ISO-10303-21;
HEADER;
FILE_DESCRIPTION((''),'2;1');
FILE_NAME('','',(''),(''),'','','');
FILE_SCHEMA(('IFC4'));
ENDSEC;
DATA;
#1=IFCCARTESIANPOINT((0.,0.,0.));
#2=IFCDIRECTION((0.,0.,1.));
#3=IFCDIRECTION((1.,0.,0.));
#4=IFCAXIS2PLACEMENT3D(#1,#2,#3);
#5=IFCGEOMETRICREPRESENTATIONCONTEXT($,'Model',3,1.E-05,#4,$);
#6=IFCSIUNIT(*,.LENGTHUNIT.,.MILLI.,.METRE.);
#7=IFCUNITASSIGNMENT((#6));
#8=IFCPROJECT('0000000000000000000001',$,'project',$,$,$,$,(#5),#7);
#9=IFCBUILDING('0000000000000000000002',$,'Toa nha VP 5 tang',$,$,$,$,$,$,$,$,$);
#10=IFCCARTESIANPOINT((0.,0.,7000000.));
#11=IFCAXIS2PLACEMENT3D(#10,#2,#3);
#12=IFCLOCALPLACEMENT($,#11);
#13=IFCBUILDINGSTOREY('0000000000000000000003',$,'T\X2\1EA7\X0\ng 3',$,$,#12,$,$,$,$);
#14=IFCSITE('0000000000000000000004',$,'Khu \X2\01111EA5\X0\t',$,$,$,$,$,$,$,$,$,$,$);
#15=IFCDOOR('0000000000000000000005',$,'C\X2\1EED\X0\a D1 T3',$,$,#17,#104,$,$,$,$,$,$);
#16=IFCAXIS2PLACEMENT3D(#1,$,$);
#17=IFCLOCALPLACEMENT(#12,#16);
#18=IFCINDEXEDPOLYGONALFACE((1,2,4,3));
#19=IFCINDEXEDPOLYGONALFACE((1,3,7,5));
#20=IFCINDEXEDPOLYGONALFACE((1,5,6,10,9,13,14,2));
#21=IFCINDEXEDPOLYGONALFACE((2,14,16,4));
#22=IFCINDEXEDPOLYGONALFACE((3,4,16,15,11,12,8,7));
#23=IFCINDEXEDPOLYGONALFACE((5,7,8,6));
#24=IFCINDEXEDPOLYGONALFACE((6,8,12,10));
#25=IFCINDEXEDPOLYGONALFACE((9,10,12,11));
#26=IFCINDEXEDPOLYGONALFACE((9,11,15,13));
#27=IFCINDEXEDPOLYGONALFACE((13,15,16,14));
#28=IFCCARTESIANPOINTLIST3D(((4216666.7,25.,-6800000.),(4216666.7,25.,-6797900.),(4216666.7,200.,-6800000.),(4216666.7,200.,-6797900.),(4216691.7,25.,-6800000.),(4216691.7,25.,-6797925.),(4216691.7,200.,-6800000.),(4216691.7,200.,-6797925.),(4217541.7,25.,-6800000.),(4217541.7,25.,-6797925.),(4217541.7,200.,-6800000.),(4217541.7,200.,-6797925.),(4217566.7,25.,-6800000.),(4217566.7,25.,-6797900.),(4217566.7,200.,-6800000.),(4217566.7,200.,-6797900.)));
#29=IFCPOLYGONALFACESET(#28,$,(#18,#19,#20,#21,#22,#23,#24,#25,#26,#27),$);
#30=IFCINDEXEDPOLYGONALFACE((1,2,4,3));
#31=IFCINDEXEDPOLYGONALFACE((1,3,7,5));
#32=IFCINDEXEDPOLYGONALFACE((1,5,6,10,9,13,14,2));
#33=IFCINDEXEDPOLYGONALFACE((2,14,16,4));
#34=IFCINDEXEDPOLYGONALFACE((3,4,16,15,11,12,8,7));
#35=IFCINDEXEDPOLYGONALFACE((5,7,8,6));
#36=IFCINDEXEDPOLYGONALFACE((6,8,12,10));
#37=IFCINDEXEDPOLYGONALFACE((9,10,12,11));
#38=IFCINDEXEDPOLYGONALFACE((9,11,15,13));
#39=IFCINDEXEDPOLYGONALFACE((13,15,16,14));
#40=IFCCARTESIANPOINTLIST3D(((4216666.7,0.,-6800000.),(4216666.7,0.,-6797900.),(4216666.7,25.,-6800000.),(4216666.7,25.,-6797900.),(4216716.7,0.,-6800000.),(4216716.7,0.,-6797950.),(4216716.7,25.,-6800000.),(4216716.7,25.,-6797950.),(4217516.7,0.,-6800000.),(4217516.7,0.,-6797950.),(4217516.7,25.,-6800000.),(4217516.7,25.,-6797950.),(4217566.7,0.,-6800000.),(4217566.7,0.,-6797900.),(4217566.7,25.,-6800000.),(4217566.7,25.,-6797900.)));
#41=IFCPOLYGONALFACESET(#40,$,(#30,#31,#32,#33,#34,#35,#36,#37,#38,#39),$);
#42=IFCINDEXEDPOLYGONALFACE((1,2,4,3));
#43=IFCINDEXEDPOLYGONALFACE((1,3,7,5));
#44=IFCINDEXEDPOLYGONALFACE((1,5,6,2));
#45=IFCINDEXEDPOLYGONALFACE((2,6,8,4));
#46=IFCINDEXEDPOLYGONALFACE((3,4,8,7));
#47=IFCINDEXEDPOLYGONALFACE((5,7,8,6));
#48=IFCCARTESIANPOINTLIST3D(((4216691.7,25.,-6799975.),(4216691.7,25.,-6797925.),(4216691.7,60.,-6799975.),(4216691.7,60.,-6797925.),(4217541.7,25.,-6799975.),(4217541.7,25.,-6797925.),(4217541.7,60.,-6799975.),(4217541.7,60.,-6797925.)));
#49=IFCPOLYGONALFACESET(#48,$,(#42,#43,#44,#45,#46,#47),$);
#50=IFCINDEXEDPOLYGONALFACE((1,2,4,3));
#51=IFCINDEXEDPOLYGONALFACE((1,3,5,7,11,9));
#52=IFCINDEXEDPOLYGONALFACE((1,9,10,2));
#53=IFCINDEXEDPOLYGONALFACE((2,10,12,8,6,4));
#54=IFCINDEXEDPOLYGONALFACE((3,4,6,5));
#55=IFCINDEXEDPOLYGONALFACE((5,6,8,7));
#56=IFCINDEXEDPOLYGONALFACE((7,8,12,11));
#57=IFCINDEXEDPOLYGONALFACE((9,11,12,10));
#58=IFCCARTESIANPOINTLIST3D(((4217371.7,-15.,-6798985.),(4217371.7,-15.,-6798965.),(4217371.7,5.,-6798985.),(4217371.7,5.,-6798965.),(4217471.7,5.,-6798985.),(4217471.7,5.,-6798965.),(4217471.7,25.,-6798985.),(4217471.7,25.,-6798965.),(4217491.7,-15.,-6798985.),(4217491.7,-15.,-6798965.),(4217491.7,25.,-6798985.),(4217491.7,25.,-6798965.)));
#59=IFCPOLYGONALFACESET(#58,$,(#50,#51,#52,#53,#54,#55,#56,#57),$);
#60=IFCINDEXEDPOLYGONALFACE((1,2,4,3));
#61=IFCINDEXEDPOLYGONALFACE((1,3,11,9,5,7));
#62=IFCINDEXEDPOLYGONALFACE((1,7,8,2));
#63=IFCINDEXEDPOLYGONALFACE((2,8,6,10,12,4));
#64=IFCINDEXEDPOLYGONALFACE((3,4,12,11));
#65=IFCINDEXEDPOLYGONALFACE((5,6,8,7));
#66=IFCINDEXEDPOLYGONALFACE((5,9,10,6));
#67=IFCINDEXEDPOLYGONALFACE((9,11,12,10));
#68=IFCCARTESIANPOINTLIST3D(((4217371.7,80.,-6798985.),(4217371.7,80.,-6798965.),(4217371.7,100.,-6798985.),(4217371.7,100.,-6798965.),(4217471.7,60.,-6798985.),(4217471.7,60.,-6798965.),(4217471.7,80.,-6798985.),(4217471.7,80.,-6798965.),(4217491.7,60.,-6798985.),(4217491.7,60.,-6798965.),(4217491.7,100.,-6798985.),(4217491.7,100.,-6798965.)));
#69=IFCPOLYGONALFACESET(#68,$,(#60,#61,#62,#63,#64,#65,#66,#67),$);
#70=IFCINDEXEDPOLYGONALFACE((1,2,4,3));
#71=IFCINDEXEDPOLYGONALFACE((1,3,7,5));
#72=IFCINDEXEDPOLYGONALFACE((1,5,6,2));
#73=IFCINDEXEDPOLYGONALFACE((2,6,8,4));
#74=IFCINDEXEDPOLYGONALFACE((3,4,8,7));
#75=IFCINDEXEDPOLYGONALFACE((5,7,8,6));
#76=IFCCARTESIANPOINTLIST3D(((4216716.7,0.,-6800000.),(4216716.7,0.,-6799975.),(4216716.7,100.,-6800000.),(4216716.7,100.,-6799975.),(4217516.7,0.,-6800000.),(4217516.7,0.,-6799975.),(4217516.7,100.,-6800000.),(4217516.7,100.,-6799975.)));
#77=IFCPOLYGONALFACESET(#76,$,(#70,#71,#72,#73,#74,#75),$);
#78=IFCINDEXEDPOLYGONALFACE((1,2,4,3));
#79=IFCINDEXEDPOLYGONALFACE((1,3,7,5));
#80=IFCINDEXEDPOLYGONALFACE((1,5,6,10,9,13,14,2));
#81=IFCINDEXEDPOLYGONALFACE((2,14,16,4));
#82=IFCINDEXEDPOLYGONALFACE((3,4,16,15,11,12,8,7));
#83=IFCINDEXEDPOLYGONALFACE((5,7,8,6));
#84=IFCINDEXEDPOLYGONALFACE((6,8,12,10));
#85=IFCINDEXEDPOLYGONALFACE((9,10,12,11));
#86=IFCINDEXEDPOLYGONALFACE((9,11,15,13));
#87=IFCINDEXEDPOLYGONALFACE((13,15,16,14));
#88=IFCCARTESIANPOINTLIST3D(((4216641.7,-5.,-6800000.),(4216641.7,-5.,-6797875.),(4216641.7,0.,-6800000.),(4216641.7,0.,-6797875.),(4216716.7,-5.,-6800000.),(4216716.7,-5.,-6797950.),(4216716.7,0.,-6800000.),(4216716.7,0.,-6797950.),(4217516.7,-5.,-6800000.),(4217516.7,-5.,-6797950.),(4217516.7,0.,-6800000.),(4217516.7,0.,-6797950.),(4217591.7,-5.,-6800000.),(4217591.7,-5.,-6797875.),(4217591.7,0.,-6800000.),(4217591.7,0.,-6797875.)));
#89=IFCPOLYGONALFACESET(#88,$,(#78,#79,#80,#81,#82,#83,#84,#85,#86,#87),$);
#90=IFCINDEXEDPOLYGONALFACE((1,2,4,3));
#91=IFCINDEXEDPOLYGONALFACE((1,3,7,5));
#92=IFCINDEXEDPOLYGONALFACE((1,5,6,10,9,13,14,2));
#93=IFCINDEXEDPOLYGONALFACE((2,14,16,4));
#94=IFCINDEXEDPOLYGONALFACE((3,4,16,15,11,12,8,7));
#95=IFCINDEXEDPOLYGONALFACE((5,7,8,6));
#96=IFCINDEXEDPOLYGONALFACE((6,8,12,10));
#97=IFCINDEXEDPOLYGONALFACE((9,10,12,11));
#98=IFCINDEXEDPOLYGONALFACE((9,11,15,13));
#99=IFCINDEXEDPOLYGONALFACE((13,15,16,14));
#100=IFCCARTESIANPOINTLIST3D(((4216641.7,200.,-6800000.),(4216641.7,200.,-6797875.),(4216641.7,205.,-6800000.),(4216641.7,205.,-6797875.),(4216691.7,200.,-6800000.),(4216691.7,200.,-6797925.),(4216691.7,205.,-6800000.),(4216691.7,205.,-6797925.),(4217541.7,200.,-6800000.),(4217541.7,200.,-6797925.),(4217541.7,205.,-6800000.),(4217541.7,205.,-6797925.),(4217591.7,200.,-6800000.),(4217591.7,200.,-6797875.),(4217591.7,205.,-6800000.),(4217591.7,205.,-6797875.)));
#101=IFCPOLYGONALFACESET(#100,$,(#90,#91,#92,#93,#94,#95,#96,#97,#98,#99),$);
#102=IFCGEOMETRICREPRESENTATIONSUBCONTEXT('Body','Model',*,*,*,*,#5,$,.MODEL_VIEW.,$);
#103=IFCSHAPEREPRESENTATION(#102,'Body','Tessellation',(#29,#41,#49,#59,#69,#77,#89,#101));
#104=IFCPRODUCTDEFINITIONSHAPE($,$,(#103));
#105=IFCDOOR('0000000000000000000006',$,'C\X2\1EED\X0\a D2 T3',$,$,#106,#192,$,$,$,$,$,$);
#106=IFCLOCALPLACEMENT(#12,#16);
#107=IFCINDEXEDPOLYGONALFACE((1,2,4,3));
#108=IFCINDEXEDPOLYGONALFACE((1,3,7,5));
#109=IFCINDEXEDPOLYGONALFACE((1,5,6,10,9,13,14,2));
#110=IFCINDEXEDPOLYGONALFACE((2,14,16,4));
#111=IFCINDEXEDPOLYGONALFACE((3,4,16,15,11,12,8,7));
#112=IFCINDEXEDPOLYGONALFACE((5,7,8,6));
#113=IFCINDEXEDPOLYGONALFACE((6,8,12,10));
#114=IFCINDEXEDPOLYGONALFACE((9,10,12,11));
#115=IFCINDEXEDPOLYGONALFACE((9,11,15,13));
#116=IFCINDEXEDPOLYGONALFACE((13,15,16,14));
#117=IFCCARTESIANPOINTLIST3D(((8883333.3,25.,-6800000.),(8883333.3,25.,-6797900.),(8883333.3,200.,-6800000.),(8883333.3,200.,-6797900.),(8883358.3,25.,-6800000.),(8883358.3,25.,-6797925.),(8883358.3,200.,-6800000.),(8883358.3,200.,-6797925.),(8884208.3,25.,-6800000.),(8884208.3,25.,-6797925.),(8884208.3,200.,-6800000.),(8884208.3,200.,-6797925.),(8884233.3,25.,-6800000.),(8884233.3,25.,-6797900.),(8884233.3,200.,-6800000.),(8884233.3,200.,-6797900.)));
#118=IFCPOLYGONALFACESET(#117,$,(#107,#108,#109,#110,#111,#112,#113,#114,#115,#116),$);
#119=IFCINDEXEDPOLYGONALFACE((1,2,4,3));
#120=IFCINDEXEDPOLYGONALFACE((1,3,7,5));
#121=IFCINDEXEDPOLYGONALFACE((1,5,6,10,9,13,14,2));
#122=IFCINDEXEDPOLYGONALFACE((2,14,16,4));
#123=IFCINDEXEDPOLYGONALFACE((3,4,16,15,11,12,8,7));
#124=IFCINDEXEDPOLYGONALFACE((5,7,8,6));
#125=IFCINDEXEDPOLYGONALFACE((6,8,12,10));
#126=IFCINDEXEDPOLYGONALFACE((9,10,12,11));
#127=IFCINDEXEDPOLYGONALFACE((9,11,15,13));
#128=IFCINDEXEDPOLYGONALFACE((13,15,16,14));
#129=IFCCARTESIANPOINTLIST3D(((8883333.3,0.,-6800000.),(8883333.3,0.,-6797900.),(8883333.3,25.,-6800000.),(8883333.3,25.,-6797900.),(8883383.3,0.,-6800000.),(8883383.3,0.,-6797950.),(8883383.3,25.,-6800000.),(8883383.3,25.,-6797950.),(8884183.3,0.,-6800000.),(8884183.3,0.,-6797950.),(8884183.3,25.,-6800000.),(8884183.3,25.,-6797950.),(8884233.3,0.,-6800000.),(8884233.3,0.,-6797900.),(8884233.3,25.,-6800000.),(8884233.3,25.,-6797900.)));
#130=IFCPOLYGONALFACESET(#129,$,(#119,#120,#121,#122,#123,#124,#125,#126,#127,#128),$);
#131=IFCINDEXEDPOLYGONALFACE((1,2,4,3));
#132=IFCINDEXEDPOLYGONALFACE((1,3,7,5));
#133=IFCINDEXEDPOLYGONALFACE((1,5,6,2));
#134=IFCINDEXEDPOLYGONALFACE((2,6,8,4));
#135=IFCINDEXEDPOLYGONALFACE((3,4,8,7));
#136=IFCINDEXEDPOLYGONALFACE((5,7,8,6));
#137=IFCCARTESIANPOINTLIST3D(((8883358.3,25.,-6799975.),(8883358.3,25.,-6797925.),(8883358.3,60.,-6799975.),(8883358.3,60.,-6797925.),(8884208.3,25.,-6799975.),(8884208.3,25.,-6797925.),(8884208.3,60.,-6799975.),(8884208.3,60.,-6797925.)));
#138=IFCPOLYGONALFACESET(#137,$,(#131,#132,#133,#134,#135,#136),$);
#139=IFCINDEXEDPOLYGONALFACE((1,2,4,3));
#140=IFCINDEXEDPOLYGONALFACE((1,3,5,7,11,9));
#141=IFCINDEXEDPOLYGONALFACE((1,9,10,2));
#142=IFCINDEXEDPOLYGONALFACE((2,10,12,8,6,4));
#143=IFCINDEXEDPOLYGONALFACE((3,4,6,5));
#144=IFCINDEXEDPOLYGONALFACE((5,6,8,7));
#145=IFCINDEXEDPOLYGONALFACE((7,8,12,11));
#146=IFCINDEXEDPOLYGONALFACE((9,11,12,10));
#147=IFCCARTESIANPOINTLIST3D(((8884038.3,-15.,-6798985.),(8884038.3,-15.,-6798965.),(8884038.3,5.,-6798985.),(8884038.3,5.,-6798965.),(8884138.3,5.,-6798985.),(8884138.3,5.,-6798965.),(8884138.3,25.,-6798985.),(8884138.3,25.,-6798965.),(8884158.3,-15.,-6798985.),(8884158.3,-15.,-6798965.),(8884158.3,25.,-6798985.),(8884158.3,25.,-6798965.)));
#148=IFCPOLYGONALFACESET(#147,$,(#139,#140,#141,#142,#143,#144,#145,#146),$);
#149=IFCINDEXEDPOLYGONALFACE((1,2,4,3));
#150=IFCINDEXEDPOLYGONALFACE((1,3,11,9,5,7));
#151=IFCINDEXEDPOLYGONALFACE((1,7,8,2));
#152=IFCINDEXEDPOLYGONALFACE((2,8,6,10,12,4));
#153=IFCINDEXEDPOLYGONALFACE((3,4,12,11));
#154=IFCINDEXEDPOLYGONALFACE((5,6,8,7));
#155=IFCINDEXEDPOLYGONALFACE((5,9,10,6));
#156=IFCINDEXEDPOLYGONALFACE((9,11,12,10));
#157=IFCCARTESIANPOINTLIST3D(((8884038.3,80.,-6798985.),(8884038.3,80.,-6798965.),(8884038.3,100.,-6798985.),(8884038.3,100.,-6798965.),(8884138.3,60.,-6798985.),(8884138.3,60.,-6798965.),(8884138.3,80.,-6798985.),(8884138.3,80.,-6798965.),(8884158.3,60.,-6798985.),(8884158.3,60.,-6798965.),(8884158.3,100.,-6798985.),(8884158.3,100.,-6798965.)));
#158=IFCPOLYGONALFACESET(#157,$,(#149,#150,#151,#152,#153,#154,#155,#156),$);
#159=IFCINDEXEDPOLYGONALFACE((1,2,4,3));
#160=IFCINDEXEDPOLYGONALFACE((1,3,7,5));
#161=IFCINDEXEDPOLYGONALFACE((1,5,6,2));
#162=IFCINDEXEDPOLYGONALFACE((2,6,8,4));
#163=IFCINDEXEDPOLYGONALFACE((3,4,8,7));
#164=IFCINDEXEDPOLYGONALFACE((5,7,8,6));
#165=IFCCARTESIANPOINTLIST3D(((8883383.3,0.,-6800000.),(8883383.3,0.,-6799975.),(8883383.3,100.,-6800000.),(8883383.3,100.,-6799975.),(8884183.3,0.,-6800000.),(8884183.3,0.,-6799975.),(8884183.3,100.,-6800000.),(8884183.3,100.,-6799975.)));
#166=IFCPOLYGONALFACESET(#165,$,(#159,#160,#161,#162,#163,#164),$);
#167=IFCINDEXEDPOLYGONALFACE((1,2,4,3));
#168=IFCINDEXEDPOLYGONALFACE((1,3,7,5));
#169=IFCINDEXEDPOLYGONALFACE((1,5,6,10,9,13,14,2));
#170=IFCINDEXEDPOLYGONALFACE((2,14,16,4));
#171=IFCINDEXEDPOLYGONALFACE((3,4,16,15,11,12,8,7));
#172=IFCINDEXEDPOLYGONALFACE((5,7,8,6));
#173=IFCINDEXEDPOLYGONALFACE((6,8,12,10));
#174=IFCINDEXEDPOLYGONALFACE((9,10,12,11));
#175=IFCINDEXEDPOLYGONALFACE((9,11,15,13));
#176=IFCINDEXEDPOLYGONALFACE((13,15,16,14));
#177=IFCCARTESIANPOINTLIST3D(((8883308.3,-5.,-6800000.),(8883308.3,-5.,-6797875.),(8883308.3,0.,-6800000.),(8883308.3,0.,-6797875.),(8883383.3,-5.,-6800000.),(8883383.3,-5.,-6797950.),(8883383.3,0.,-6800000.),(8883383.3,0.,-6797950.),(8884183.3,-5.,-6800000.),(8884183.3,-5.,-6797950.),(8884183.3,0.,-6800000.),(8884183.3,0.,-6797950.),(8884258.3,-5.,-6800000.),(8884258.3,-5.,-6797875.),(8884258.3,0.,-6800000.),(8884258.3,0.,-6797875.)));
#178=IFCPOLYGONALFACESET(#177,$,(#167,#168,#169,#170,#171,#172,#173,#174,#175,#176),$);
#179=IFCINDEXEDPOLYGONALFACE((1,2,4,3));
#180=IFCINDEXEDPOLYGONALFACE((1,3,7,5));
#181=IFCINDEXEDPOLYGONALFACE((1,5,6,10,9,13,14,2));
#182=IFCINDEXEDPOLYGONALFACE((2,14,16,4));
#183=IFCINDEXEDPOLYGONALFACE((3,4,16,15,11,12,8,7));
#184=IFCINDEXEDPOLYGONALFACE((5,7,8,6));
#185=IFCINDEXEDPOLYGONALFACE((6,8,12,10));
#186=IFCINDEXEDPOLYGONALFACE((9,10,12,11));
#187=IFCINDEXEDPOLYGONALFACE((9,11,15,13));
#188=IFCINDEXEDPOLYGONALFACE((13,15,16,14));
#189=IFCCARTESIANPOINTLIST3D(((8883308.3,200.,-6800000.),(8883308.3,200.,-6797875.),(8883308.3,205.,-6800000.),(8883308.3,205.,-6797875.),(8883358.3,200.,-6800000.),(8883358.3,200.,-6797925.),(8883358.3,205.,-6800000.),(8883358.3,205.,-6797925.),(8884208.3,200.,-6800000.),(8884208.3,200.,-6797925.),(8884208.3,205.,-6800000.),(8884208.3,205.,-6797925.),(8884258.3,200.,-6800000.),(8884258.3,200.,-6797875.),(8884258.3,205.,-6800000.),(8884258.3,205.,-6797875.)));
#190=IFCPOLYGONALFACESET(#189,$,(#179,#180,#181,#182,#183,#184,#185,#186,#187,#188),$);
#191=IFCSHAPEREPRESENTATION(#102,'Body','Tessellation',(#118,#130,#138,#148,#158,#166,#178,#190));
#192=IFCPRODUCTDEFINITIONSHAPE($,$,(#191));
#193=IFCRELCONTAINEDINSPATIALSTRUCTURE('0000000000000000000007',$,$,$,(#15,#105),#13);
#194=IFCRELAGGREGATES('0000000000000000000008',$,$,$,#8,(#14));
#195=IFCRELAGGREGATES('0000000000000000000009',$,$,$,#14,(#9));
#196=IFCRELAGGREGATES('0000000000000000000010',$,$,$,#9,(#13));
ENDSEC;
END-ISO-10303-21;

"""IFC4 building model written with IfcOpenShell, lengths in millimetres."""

from ifc_helpers import new_model, si_unit, frame, origin_with_axes, place, context, subcontext, project, spatial, line, indexed_curve, outline, extrude, element, save


model = new_model("IFC4")

# Units and contexts
model_context = context("Model", 3, precision=1e-05, world=origin_with_axes())
body_context = subcontext(model_context, "Body", "Model", "MODEL_VIEW")
ifc_project = project(units=[si_unit("LENGTHUNIT", "METRE", prefix="MILLI")], contexts=[model_context])

# Site, building, storey
site = spatial("IfcSite", under=ifc_project, Name="Khu đất")
building = spatial("IfcBuilding", under=site, Name="Toa nha VP 5 tang")
storey_placement = place(None, frame((0.0, 0.0, 7000000.0), z_axis=(0.0, 0.0, 1.0), x_axis=(1.0, 0.0, 0.0)))
storey = spatial("IfcBuildingStorey", under=building, at=storey_placement, Name="Tầng 3")

# Doors
door_1_placement = place(storey_placement, frame((4216666.7, 0.0, -6800000.0), z_axis=(0.0, 0.0, 1.0), x_axis=(1.0, 0.0, 0.0)))
element("IfcDoor", 1, at=door_1_placement, inside=storey, Name="Cửa D1 T3", context=body_context, shape_type="SolidModel", body=[
    extrude(outline(indexed_curve([(0.0, 0.0), (0.0, 2100.0), (900.0, 2100.0), (900.0, 0.0), (875.0, 0.0), (875.0, 2075.0), (25.0, 2075.0), (25.0, 0.0)], segments=[line(1, 2, 3, 4, 5, 6, 7, 8, 1)])), frame((0.0, 25.0, 0.0), z_axis=(0.0, -1.0, 0.0), x_axis=(1.0, 0.0, 0.0)), (0.0, 0.0, -1.0), 175.0),
    extrude(outline(indexed_curve([(0.0, 0.0), (0.0, 2100.0), (900.0, 2100.0), (900.0, 0.0), (850.0, 0.0), (850.0, 2050.0), (50.0, 2050.0), (50.0, 0.0)], segments=[line(1, 2, 3, 4, 5, 6, 7, 8, 1)])), frame((0.0, 0.0, 0.0), z_axis=(0.0, -1.0, 0.0), x_axis=(1.0, 0.0, 0.0)), (0.0, 0.0, -1.0), 25.0),
    extrude(outline(indexed_curve([(0.0, 0.0), (850.0, 0.0), (850.0, 35.0), (0.0, 35.0)], segments=[line(1, 2, 3, 4, 1)])), frame((25.0, 25.0, 25.0), z_axis=(0.0, 0.0, 1.0), x_axis=(1.0, 0.0, 0.0)), (0.0, 0.0, 1.0), 2050.0),
    extrude(outline(indexed_curve([(0.0, 0.0), (0.0, -40.0), (-120.0, -40.0), (-120.0, -20.0), (-20.0, -20.0), (-20.0, 0.0)], segments=[line(1, 2, 3, 4, 5, 6, 1)])), frame((825.0, 25.0, 1015.0), z_axis=(0.0, 0.0, 1.0), x_axis=(1.0, 0.0, 0.0)), (0.0, 0.0, 1.0), 20.0),
    extrude(outline(indexed_curve([(0.0, 0.0), (0.0, 40.0), (-120.0, 40.0), (-120.0, 20.0), (-20.0, 20.0), (-20.0, 0.0)], segments=[line(1, 2, 3, 4, 5, 6, 1)])), frame((825.0, 60.0, 1015.0), z_axis=(0.0, 0.0, 1.0), x_axis=(1.0, 0.0, 0.0)), (0.0, 0.0, 1.0), 20.0),
    extrude(outline(indexed_curve([(0.0, 0.0), (800.0, 0.0), (800.0, 100.0), (0.0, 100.0)], segments=[line(1, 2, 3, 4, 1)])), frame((50.0, 0.0, 0.0), z_axis=(0.0, 0.0, 1.0), x_axis=(1.0, 0.0, 0.0)), (0.0, 0.0, 1.0), 25.0),
    extrude(outline(indexed_curve([(0.0, 0.0), (0.0, 2125.0), (950.0, 2125.0), (950.0, 0.0), (875.0, 0.0), (875.0, 2050.0), (75.0, 2050.0), (75.0, 0.0)], segments=[line(1, 2, 3, 4, 5, 6, 7, 8, 1)])), frame((-25.0, -5.0, 0.0), z_axis=(0.0, -1.0, 0.0), x_axis=(1.0, 0.0, 0.0)), (0.0, 0.0, -1.0), 5.0),
    extrude(outline(indexed_curve([(0.0, 0.0), (0.0, 2125.0), (950.0, 2125.0), (950.0, 0.0), (900.0, 0.0), (900.0, 2075.0), (50.0, 2075.0), (50.0, 0.0)], segments=[line(1, 2, 3, 4, 5, 6, 7, 8, 1)])), frame((-25.0, 200.0, 0.0), z_axis=(0.0, -1.0, 0.0), x_axis=(1.0, 0.0, 0.0)), (0.0, 0.0, -1.0), 5.0),
])
door_2_placement = place(storey_placement, frame((8883333.3, 0.0, -6800000.0), z_axis=(0.0, 0.0, 1.0), x_axis=(1.0, 0.0, 0.0)))
element("IfcDoor", 2, at=door_2_placement, inside=storey, Name="Cửa D2 T3", context=body_context, shape_type="SolidModel", body=[
    extrude(outline(indexed_curve([(0.0, 0.0), (0.0, 2100.0), (900.0, 2100.0), (900.0, 0.0), (875.0, 0.0), (875.0, 2075.0), (25.0, 2075.0), (25.0, 0.0)], segments=[line(1, 2, 3, 4, 5, 6, 7, 8, 1)])), frame((0.0, 25.0, 0.0), z_axis=(0.0, -1.0, 0.0), x_axis=(1.0, 0.0, 0.0)), (0.0, 0.0, -1.0), 175.0),
    extrude(outline(indexed_curve([(0.0, 0.0), (0.0, 2100.0), (900.0, 2100.0), (900.0, 0.0), (850.0, 0.0), (850.0, 2050.0), (50.0, 2050.0), (50.0, 0.0)], segments=[line(1, 2, 3, 4, 5, 6, 7, 8, 1)])), frame((0.0, 0.0, 0.0), z_axis=(0.0, -1.0, 0.0), x_axis=(1.0, 0.0, 0.0)), (0.0, 0.0, -1.0), 25.0),
    extrude(outline(indexed_curve([(0.0, 0.0), (850.0, 0.0), (850.0, 35.0), (0.0, 35.0)], segments=[line(1, 2, 3, 4, 1)])), frame((25.0, 25.0, 25.0), z_axis=(0.0, 0.0, 1.0), x_axis=(1.0, 0.0, 0.0)), (0.0, 0.0, 1.0), 2050.0),
    extrude(outline(indexed_curve([(0.0, 0.0), (0.0, -40.0), (-120.0, -40.0), (-120.0, -20.0), (-20.0, -20.0), (-20.0, 0.0)], segments=[line(1, 2, 3, 4, 5, 6, 1)])), frame((825.0, 25.0, 1015.0), z_axis=(0.0, 0.0, 1.0), x_axis=(1.0, 0.0, 0.0)), (0.0, 0.0, 1.0), 20.0),
    extrude(outline(indexed_curve([(0.0, 0.0), (0.0, 40.0), (-120.0, 40.0), (-120.0, 20.0), (-20.0, 20.0), (-20.0, 0.0)], segments=[line(1, 2, 3, 4, 5, 6, 1)])), frame((825.0, 60.0, 1015.0), z_axis=(0.0, 0.0, 1.0), x_axis=(1.0, 0.0, 0.0)), (0.0, 0.0, 1.0), 20.0),
    extrude(outline(indexed_curve([(0.0, 0.0), (800.0, 0.0), (800.0, 100.0), (0.0, 100.0)], segments=[line(1, 2, 3, 4, 1)])), frame((50.0, 0.0, 0.0), z_axis=(0.0, 0.0, 1.0), x_axis=(1.0, 0.0, 0.0)), (0.0, 0.0, 1.0), 25.0),
    extrude(outline(indexed_curve([(0.0, 0.0), (0.0, 2125.0), (950.0, 2125.0), (950.0, 0.0), (875.0, 0.0), (875.0, 2050.0), (75.0, 2050.0), (75.0, 0.0)], segments=[line(1, 2, 3, 4, 5, 6, 7, 8, 1)])), frame((-25.0, -5.0, 0.0), z_axis=(0.0, -1.0, 0.0), x_axis=(1.0, 0.0, 0.0)), (0.0, 0.0, -1.0), 5.0),
    extrude(outline(indexed_curve([(0.0, 0.0), (0.0, 2125.0), (950.0, 2125.0), (950.0, 0.0), (900.0, 0.0), (900.0, 2075.0), (50.0, 2075.0), (50.0, 0.0)], segments=[line(1, 2, 3, 4, 5, 6, 7, 8, 1)])), frame((-25.0, 200.0, 0.0), z_axis=(0.0, -1.0, 0.0), x_axis=(1.0, 0.0, 0.0)), (0.0, 0.0, -1.0), 5.0),
])

save(model, "model.ifc")
